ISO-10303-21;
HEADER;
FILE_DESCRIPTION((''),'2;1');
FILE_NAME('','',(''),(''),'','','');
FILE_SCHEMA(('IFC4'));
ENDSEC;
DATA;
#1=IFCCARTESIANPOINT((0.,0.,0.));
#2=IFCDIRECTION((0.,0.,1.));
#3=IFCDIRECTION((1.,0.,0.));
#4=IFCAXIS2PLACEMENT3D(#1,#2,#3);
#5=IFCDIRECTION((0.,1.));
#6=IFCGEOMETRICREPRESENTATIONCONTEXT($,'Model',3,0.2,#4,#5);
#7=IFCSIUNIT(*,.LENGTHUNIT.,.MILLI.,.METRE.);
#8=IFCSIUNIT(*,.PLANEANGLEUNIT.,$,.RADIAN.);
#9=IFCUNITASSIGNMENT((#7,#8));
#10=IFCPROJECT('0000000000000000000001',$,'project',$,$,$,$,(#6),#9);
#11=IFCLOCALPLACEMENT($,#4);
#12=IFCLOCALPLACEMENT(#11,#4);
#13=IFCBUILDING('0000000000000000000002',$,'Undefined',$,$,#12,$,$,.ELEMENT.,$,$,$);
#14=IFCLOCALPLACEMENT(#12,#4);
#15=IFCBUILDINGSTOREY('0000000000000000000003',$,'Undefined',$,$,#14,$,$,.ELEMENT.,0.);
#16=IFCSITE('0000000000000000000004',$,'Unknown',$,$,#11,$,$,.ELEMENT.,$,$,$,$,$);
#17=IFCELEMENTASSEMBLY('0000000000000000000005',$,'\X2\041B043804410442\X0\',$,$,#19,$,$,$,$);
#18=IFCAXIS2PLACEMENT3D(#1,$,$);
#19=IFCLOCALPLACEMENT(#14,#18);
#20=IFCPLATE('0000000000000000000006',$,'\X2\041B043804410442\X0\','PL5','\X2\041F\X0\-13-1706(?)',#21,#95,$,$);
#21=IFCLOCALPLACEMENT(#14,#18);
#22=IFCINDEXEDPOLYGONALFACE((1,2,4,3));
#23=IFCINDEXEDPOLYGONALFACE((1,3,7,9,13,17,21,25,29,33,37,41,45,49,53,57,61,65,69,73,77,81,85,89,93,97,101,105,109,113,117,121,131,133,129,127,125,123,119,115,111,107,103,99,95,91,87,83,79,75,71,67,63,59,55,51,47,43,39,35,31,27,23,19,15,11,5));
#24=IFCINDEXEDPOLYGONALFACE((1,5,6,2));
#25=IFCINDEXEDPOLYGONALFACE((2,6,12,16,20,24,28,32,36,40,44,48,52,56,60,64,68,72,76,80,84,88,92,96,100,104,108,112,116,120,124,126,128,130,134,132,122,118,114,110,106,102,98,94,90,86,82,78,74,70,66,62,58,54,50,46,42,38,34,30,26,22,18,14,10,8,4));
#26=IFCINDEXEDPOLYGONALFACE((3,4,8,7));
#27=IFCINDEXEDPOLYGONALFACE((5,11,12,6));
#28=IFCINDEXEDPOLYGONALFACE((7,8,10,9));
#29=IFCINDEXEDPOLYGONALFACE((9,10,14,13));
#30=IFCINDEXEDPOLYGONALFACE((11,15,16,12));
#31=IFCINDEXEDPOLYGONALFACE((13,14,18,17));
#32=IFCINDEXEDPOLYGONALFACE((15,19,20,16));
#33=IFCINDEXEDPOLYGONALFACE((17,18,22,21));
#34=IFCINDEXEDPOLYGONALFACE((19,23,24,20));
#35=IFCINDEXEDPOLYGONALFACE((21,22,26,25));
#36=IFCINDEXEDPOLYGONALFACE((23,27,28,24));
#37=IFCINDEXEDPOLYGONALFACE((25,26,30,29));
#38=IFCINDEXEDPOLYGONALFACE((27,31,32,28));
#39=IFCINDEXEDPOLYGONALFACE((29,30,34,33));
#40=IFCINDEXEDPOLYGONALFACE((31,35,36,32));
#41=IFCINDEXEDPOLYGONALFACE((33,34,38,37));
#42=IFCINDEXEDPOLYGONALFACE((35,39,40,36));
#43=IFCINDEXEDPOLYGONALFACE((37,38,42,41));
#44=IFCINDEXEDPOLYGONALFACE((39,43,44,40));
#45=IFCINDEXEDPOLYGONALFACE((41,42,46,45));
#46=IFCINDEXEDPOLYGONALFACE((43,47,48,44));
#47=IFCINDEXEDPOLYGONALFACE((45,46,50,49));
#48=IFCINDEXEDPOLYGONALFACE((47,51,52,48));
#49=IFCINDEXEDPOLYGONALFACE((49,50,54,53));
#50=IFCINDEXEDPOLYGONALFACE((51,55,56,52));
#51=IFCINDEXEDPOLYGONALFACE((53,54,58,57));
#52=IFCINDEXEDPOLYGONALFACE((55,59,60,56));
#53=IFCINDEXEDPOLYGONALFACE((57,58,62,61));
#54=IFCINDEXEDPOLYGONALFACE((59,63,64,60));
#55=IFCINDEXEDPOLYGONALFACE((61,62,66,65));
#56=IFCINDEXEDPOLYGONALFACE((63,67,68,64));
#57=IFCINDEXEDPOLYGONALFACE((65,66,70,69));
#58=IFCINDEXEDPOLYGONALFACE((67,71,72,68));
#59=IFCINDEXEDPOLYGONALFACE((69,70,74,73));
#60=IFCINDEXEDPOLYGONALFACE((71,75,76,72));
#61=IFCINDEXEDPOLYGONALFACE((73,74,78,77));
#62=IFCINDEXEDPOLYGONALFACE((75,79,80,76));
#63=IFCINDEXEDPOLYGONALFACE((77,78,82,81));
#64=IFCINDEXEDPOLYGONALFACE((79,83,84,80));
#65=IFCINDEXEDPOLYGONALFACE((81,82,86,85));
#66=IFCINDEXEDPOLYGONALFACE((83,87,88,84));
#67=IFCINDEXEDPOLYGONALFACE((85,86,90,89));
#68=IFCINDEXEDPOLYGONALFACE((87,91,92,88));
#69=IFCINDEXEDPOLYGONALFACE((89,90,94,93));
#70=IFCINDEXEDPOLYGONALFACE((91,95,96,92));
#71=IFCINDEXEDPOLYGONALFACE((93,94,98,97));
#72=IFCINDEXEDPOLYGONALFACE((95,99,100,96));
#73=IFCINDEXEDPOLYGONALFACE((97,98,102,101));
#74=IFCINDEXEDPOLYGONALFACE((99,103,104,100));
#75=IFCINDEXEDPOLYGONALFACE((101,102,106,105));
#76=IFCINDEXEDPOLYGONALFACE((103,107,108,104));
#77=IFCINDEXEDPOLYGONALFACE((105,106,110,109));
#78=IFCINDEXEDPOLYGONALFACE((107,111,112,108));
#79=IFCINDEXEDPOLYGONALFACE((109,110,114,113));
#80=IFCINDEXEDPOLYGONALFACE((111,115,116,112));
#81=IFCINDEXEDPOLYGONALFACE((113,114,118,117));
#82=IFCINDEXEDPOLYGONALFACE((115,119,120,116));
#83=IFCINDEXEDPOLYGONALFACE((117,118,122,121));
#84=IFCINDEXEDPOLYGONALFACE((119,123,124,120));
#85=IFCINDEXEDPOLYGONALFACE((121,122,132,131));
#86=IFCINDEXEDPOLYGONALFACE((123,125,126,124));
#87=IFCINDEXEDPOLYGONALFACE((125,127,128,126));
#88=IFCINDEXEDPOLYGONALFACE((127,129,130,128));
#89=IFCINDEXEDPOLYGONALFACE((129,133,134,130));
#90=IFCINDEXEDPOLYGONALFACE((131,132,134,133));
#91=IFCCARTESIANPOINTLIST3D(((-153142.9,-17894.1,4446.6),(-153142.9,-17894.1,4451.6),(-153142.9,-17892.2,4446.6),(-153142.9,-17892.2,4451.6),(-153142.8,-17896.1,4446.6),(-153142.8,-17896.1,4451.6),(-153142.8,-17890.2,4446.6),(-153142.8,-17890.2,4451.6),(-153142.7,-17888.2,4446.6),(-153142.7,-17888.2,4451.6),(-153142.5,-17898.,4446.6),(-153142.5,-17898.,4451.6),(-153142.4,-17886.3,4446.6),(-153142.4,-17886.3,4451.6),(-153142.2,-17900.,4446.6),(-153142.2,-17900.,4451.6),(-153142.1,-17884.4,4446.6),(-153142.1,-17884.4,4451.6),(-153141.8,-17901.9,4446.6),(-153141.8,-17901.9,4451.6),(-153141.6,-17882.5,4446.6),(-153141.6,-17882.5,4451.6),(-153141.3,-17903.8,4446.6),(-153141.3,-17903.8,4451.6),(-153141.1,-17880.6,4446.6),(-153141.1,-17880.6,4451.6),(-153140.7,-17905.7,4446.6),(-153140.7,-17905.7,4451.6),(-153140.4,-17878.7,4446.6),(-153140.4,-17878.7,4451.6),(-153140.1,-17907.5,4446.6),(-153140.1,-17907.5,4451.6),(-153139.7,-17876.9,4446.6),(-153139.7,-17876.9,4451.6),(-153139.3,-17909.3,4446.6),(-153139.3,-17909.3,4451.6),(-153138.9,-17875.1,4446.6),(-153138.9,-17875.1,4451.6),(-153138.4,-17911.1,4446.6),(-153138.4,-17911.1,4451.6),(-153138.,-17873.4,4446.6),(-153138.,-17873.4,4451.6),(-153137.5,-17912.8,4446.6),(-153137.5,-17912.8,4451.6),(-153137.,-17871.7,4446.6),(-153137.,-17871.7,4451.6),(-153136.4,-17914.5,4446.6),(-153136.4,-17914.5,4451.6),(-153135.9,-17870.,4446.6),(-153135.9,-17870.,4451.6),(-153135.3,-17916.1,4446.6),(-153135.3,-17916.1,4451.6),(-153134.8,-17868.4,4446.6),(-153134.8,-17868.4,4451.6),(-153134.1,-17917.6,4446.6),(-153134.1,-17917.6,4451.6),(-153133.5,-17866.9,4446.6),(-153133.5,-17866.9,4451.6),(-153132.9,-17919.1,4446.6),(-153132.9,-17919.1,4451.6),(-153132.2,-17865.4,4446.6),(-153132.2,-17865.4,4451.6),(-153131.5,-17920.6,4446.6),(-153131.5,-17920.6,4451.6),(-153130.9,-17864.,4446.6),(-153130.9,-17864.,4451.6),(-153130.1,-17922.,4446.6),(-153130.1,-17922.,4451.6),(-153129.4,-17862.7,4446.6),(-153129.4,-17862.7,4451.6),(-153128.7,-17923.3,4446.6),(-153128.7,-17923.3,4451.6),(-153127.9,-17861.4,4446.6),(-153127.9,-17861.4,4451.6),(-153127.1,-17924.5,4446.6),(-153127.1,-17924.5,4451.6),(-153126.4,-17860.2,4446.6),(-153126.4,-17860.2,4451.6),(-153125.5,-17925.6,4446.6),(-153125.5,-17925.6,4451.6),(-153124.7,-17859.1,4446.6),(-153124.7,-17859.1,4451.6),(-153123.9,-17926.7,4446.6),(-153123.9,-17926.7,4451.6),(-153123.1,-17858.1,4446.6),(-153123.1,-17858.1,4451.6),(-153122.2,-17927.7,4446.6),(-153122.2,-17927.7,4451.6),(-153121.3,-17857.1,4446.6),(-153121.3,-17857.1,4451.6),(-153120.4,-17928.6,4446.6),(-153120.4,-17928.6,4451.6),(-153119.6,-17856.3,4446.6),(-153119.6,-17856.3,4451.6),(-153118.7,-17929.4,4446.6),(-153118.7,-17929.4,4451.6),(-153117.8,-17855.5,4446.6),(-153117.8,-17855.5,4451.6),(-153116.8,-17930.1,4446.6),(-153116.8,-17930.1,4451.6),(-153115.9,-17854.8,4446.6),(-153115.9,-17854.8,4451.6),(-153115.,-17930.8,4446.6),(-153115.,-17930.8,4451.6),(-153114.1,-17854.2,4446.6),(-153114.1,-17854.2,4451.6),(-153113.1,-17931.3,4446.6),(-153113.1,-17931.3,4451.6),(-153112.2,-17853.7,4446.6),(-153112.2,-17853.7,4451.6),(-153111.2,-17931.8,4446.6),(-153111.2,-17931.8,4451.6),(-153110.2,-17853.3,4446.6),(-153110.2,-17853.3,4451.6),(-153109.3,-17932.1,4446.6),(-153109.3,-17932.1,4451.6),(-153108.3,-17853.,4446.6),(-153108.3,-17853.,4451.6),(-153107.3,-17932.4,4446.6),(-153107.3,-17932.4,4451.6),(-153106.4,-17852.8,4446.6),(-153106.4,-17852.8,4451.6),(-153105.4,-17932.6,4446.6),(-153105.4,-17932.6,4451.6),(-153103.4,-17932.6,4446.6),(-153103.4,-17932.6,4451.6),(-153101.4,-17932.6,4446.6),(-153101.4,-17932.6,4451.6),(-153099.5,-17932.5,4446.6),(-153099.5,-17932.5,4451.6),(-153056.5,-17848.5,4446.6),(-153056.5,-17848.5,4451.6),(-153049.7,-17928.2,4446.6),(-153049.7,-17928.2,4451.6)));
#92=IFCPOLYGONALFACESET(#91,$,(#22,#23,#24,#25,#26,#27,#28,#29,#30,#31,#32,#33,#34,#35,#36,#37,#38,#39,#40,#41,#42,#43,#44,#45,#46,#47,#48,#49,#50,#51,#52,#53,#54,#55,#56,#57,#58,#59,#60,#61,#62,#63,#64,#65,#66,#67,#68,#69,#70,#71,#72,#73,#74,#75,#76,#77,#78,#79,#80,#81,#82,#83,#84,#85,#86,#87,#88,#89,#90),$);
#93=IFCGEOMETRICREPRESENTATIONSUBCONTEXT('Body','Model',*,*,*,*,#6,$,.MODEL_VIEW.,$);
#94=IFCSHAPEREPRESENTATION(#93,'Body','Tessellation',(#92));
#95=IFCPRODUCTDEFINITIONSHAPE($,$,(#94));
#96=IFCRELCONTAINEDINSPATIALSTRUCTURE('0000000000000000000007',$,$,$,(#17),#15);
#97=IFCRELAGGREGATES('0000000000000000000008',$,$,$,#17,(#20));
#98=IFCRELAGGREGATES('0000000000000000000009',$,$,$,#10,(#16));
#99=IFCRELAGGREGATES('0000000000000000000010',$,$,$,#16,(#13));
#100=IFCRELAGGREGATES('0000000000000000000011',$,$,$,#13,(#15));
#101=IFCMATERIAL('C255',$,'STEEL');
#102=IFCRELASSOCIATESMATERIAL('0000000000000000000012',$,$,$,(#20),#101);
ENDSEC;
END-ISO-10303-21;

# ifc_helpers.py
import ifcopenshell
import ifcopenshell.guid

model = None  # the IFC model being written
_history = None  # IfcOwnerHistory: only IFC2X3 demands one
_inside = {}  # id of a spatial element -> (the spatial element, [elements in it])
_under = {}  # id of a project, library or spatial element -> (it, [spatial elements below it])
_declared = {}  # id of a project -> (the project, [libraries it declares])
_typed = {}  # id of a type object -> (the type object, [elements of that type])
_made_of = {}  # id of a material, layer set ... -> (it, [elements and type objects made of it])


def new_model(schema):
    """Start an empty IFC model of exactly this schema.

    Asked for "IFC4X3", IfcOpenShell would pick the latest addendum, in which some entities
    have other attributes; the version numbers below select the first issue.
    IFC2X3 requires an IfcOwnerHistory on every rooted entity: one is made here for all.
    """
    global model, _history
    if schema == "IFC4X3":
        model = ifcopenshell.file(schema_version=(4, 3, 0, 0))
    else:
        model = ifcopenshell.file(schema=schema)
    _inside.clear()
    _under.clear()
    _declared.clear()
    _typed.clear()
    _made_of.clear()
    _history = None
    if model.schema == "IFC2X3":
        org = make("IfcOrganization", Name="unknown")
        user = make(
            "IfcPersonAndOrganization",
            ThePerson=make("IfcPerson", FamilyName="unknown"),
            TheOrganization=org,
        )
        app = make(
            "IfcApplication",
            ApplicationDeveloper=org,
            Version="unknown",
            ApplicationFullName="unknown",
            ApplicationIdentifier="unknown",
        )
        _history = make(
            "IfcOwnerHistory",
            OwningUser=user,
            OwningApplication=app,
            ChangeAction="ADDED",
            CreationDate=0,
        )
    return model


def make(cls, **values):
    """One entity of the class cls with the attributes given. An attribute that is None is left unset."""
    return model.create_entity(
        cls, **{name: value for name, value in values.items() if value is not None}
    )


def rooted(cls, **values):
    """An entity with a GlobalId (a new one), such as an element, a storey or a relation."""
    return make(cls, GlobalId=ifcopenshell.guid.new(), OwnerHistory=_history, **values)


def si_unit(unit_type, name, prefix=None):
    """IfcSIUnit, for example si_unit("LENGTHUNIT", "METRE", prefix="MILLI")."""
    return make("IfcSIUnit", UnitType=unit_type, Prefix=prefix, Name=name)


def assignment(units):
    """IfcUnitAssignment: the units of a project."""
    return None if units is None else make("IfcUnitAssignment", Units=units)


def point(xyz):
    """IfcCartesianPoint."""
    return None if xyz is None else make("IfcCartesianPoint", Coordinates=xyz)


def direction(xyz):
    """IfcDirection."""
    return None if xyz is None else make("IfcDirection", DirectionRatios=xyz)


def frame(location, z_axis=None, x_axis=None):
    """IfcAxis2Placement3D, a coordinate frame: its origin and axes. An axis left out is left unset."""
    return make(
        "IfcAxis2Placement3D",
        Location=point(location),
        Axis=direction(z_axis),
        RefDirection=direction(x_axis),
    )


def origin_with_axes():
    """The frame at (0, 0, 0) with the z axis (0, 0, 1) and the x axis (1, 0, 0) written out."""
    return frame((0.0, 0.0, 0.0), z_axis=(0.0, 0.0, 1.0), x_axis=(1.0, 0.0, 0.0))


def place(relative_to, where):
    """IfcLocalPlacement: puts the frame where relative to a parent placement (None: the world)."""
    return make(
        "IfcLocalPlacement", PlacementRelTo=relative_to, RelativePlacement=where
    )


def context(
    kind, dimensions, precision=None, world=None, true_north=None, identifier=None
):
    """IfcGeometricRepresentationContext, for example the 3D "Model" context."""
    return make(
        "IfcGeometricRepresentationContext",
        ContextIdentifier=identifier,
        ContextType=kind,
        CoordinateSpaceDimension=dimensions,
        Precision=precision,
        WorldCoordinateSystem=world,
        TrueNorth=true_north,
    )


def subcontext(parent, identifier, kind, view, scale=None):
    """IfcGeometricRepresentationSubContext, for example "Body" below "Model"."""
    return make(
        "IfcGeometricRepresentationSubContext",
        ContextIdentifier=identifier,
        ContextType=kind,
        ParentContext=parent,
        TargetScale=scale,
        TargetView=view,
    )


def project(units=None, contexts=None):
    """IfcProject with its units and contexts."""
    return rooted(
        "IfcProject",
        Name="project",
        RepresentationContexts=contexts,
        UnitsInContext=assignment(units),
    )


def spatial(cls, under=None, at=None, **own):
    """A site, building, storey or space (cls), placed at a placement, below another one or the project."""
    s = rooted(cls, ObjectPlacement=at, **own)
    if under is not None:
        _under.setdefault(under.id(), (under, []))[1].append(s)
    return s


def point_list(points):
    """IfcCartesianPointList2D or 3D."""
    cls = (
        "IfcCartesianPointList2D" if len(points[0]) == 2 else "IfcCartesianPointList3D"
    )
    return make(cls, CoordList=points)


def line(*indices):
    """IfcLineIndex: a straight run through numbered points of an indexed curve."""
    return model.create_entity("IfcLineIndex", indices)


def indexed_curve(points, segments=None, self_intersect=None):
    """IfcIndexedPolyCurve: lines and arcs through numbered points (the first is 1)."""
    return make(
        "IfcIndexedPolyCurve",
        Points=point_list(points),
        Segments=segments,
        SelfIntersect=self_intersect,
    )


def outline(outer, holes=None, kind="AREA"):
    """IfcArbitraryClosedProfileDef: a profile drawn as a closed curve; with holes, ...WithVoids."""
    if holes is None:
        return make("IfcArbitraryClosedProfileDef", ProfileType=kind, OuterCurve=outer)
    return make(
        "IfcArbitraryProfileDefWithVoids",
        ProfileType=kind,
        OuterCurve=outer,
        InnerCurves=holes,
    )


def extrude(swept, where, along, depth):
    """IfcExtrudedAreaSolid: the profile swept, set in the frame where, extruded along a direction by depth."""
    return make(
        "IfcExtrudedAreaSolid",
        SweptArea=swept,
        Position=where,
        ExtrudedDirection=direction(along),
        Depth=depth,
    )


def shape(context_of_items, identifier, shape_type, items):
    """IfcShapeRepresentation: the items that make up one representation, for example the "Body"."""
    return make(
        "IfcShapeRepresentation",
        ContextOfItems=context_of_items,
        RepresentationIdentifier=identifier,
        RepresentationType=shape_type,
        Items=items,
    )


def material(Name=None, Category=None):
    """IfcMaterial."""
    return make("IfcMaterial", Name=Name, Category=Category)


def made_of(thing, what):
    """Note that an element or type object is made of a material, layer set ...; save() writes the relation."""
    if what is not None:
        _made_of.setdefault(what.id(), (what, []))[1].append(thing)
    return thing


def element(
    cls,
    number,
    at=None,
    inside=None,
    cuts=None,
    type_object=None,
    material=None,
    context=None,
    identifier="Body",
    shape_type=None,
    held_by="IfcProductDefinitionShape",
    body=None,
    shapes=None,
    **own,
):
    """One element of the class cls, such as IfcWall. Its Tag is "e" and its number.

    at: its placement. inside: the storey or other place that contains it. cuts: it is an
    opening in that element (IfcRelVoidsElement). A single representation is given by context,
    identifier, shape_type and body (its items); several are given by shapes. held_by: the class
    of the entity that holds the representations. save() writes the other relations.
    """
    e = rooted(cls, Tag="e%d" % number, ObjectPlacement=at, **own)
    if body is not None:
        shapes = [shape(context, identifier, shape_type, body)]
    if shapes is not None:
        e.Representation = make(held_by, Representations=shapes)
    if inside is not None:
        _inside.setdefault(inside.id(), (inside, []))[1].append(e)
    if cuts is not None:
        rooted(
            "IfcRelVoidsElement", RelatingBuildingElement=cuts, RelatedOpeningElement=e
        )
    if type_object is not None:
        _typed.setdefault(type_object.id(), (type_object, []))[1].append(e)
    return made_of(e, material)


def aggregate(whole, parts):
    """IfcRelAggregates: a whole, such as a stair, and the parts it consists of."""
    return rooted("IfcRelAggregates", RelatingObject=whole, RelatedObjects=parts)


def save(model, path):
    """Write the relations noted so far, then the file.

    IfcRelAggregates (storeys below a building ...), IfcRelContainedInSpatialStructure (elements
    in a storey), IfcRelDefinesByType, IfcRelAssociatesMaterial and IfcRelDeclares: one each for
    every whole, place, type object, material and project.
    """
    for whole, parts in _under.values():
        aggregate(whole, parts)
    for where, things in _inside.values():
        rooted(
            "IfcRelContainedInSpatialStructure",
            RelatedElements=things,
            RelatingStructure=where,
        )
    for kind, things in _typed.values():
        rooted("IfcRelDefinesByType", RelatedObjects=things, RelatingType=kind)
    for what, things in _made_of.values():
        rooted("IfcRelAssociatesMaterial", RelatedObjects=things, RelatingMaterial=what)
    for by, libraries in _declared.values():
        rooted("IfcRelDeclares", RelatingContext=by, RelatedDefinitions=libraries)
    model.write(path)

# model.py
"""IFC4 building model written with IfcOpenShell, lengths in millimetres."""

from ifc_helpers import new_model, si_unit, direction, frame, origin_with_axes, place, context, subcontext, project, spatial, line, indexed_curve, outline, extrude, material, element, aggregate, save


model = new_model("IFC4")

# Units and contexts
model_context = context("Model", 3, precision=0.2, world=origin_with_axes(), true_north=direction((0.0, 1.0)))
body_context = subcontext(model_context, "Body", "Model", "MODEL_VIEW")
ifc_project = project(units=[si_unit("LENGTHUNIT", "METRE", prefix="MILLI"), si_unit("PLANEANGLEUNIT", "RADIAN")], contexts=[model_context])

# Site, building, storey
site_placement = place(None, origin_with_axes())
site = spatial("IfcSite", under=ifc_project, at=site_placement, Name="Unknown", CompositionType="ELEMENT")
building_placement = place(site_placement, origin_with_axes())
building = spatial("IfcBuilding", under=site, at=building_placement, Name="Undefined", CompositionType="ELEMENT")
storey_placement = place(building_placement, origin_with_axes())
storey = spatial("IfcBuildingStorey", under=building, at=storey_placement, Name="Undefined", CompositionType="ELEMENT", Elevation=0.0)

# Shared definitions
ifc_material_1 = material(Name="C255", Category="STEEL")

# Element assembly, plate
assembly_1_placement = place(storey_placement, frame((-153042.9, -17977.8, 4406.6), z_axis=(-0.996285, -0.086114, 0.0), x_axis=(0.0, 0.0, 1.0)))
assembly_1 = element("IfcElementAssembly", 1, at=assembly_1_placement, inside=storey, Name="Лист")
plate_1_placement = place(assembly_1_placement, frame((42.5, 50.0, 2.5), z_axis=(1.0, 0.0, 0.0), x_axis=(0.0, 1.0, 0.0)))
plate_1 = element("IfcPlate", 2, at=plate_1_placement, material=ifc_material_1, Name="Лист", Description="PL5", ObjectType="П-13-1706(?)", context=body_context, shape_type="SolidModel", body=[
    extrude(outline(indexed_curve([(0.0, 0.0), (80.0, 0.0), (80.0, 50.0), (80.0, 52.0), (79.8, 53.9), (79.6, 55.9), (79.2, 57.8), (78.8, 59.7), (78.3, 61.6), (77.7, 63.5), (77.0, 65.3), (76.2, 67.1), (75.3, 68.9), (74.3, 70.6), (73.3, 72.2), (72.1, 73.8), (70.9, 75.4), (69.6, 76.9), (68.3, 78.3), (66.9, 79.6), (65.4, 80.9), (63.8, 82.1), (62.2, 83.3), (60.6, 84.3), (58.9, 85.3), (57.1, 86.2), (55.3, 87.0), (53.5, 87.7), (51.6, 88.3), (49.7, 88.8), (47.8, 89.2), (45.9, 89.6), (43.9, 89.8), (42.0, 90.0), (40.0, 90.0), (40.0, 90.0), (38.0, 90.0), (36.1, 89.8), (34.1, 89.6), (32.2, 89.2), (30.3, 88.8), (28.4, 88.3), (26.5, 87.7), (24.7, 87.0), (22.9, 86.2), (21.1, 85.3), (19.4, 84.3), (17.8, 83.3), (16.2, 82.1), (14.6, 80.9), (13.1, 79.6), (11.7, 78.3), (10.4, 76.9), (9.1, 75.4), (7.9, 73.8), (6.7, 72.2), (5.7, 70.6), (4.7, 68.9), (3.8, 67.1), (3.0, 65.3), (2.3, 63.5), (1.7, 61.6), (1.2, 59.7), (0.8, 57.8), (0.4, 55.9), (0.2, 53.9), (0.0, 52.0), (0.0, 50.0)], segments=[line(1, 2, 3, 4, 5, 6, 7, 8, 9, 10, 11, 12, 13, 14, 15, 16, 17, 18, 19, 20, 21, 22, 23, 24, 25, 26, 27, 28, 29, 30, 31, 32, 33, 34, 35, 36, 37, 38, 39, 40, 41, 42, 43, 44, 45, 46, 47, 48, 49, 50, 51, 52, 53, 54, 55, 56, 57, 58, 59, 60, 61, 62, 63, 64, 65, 66, 67, 68, 1)])), frame((0.0, 0.0, 2.5), z_axis=(0.0, 0.0, 1.0), x_axis=(1.0, 0.0, 0.0)), (0.0, 0.0, -1.0), 5.0),
])

aggregate(assembly_1, [plate_1])

save(model, "model.ifc")
